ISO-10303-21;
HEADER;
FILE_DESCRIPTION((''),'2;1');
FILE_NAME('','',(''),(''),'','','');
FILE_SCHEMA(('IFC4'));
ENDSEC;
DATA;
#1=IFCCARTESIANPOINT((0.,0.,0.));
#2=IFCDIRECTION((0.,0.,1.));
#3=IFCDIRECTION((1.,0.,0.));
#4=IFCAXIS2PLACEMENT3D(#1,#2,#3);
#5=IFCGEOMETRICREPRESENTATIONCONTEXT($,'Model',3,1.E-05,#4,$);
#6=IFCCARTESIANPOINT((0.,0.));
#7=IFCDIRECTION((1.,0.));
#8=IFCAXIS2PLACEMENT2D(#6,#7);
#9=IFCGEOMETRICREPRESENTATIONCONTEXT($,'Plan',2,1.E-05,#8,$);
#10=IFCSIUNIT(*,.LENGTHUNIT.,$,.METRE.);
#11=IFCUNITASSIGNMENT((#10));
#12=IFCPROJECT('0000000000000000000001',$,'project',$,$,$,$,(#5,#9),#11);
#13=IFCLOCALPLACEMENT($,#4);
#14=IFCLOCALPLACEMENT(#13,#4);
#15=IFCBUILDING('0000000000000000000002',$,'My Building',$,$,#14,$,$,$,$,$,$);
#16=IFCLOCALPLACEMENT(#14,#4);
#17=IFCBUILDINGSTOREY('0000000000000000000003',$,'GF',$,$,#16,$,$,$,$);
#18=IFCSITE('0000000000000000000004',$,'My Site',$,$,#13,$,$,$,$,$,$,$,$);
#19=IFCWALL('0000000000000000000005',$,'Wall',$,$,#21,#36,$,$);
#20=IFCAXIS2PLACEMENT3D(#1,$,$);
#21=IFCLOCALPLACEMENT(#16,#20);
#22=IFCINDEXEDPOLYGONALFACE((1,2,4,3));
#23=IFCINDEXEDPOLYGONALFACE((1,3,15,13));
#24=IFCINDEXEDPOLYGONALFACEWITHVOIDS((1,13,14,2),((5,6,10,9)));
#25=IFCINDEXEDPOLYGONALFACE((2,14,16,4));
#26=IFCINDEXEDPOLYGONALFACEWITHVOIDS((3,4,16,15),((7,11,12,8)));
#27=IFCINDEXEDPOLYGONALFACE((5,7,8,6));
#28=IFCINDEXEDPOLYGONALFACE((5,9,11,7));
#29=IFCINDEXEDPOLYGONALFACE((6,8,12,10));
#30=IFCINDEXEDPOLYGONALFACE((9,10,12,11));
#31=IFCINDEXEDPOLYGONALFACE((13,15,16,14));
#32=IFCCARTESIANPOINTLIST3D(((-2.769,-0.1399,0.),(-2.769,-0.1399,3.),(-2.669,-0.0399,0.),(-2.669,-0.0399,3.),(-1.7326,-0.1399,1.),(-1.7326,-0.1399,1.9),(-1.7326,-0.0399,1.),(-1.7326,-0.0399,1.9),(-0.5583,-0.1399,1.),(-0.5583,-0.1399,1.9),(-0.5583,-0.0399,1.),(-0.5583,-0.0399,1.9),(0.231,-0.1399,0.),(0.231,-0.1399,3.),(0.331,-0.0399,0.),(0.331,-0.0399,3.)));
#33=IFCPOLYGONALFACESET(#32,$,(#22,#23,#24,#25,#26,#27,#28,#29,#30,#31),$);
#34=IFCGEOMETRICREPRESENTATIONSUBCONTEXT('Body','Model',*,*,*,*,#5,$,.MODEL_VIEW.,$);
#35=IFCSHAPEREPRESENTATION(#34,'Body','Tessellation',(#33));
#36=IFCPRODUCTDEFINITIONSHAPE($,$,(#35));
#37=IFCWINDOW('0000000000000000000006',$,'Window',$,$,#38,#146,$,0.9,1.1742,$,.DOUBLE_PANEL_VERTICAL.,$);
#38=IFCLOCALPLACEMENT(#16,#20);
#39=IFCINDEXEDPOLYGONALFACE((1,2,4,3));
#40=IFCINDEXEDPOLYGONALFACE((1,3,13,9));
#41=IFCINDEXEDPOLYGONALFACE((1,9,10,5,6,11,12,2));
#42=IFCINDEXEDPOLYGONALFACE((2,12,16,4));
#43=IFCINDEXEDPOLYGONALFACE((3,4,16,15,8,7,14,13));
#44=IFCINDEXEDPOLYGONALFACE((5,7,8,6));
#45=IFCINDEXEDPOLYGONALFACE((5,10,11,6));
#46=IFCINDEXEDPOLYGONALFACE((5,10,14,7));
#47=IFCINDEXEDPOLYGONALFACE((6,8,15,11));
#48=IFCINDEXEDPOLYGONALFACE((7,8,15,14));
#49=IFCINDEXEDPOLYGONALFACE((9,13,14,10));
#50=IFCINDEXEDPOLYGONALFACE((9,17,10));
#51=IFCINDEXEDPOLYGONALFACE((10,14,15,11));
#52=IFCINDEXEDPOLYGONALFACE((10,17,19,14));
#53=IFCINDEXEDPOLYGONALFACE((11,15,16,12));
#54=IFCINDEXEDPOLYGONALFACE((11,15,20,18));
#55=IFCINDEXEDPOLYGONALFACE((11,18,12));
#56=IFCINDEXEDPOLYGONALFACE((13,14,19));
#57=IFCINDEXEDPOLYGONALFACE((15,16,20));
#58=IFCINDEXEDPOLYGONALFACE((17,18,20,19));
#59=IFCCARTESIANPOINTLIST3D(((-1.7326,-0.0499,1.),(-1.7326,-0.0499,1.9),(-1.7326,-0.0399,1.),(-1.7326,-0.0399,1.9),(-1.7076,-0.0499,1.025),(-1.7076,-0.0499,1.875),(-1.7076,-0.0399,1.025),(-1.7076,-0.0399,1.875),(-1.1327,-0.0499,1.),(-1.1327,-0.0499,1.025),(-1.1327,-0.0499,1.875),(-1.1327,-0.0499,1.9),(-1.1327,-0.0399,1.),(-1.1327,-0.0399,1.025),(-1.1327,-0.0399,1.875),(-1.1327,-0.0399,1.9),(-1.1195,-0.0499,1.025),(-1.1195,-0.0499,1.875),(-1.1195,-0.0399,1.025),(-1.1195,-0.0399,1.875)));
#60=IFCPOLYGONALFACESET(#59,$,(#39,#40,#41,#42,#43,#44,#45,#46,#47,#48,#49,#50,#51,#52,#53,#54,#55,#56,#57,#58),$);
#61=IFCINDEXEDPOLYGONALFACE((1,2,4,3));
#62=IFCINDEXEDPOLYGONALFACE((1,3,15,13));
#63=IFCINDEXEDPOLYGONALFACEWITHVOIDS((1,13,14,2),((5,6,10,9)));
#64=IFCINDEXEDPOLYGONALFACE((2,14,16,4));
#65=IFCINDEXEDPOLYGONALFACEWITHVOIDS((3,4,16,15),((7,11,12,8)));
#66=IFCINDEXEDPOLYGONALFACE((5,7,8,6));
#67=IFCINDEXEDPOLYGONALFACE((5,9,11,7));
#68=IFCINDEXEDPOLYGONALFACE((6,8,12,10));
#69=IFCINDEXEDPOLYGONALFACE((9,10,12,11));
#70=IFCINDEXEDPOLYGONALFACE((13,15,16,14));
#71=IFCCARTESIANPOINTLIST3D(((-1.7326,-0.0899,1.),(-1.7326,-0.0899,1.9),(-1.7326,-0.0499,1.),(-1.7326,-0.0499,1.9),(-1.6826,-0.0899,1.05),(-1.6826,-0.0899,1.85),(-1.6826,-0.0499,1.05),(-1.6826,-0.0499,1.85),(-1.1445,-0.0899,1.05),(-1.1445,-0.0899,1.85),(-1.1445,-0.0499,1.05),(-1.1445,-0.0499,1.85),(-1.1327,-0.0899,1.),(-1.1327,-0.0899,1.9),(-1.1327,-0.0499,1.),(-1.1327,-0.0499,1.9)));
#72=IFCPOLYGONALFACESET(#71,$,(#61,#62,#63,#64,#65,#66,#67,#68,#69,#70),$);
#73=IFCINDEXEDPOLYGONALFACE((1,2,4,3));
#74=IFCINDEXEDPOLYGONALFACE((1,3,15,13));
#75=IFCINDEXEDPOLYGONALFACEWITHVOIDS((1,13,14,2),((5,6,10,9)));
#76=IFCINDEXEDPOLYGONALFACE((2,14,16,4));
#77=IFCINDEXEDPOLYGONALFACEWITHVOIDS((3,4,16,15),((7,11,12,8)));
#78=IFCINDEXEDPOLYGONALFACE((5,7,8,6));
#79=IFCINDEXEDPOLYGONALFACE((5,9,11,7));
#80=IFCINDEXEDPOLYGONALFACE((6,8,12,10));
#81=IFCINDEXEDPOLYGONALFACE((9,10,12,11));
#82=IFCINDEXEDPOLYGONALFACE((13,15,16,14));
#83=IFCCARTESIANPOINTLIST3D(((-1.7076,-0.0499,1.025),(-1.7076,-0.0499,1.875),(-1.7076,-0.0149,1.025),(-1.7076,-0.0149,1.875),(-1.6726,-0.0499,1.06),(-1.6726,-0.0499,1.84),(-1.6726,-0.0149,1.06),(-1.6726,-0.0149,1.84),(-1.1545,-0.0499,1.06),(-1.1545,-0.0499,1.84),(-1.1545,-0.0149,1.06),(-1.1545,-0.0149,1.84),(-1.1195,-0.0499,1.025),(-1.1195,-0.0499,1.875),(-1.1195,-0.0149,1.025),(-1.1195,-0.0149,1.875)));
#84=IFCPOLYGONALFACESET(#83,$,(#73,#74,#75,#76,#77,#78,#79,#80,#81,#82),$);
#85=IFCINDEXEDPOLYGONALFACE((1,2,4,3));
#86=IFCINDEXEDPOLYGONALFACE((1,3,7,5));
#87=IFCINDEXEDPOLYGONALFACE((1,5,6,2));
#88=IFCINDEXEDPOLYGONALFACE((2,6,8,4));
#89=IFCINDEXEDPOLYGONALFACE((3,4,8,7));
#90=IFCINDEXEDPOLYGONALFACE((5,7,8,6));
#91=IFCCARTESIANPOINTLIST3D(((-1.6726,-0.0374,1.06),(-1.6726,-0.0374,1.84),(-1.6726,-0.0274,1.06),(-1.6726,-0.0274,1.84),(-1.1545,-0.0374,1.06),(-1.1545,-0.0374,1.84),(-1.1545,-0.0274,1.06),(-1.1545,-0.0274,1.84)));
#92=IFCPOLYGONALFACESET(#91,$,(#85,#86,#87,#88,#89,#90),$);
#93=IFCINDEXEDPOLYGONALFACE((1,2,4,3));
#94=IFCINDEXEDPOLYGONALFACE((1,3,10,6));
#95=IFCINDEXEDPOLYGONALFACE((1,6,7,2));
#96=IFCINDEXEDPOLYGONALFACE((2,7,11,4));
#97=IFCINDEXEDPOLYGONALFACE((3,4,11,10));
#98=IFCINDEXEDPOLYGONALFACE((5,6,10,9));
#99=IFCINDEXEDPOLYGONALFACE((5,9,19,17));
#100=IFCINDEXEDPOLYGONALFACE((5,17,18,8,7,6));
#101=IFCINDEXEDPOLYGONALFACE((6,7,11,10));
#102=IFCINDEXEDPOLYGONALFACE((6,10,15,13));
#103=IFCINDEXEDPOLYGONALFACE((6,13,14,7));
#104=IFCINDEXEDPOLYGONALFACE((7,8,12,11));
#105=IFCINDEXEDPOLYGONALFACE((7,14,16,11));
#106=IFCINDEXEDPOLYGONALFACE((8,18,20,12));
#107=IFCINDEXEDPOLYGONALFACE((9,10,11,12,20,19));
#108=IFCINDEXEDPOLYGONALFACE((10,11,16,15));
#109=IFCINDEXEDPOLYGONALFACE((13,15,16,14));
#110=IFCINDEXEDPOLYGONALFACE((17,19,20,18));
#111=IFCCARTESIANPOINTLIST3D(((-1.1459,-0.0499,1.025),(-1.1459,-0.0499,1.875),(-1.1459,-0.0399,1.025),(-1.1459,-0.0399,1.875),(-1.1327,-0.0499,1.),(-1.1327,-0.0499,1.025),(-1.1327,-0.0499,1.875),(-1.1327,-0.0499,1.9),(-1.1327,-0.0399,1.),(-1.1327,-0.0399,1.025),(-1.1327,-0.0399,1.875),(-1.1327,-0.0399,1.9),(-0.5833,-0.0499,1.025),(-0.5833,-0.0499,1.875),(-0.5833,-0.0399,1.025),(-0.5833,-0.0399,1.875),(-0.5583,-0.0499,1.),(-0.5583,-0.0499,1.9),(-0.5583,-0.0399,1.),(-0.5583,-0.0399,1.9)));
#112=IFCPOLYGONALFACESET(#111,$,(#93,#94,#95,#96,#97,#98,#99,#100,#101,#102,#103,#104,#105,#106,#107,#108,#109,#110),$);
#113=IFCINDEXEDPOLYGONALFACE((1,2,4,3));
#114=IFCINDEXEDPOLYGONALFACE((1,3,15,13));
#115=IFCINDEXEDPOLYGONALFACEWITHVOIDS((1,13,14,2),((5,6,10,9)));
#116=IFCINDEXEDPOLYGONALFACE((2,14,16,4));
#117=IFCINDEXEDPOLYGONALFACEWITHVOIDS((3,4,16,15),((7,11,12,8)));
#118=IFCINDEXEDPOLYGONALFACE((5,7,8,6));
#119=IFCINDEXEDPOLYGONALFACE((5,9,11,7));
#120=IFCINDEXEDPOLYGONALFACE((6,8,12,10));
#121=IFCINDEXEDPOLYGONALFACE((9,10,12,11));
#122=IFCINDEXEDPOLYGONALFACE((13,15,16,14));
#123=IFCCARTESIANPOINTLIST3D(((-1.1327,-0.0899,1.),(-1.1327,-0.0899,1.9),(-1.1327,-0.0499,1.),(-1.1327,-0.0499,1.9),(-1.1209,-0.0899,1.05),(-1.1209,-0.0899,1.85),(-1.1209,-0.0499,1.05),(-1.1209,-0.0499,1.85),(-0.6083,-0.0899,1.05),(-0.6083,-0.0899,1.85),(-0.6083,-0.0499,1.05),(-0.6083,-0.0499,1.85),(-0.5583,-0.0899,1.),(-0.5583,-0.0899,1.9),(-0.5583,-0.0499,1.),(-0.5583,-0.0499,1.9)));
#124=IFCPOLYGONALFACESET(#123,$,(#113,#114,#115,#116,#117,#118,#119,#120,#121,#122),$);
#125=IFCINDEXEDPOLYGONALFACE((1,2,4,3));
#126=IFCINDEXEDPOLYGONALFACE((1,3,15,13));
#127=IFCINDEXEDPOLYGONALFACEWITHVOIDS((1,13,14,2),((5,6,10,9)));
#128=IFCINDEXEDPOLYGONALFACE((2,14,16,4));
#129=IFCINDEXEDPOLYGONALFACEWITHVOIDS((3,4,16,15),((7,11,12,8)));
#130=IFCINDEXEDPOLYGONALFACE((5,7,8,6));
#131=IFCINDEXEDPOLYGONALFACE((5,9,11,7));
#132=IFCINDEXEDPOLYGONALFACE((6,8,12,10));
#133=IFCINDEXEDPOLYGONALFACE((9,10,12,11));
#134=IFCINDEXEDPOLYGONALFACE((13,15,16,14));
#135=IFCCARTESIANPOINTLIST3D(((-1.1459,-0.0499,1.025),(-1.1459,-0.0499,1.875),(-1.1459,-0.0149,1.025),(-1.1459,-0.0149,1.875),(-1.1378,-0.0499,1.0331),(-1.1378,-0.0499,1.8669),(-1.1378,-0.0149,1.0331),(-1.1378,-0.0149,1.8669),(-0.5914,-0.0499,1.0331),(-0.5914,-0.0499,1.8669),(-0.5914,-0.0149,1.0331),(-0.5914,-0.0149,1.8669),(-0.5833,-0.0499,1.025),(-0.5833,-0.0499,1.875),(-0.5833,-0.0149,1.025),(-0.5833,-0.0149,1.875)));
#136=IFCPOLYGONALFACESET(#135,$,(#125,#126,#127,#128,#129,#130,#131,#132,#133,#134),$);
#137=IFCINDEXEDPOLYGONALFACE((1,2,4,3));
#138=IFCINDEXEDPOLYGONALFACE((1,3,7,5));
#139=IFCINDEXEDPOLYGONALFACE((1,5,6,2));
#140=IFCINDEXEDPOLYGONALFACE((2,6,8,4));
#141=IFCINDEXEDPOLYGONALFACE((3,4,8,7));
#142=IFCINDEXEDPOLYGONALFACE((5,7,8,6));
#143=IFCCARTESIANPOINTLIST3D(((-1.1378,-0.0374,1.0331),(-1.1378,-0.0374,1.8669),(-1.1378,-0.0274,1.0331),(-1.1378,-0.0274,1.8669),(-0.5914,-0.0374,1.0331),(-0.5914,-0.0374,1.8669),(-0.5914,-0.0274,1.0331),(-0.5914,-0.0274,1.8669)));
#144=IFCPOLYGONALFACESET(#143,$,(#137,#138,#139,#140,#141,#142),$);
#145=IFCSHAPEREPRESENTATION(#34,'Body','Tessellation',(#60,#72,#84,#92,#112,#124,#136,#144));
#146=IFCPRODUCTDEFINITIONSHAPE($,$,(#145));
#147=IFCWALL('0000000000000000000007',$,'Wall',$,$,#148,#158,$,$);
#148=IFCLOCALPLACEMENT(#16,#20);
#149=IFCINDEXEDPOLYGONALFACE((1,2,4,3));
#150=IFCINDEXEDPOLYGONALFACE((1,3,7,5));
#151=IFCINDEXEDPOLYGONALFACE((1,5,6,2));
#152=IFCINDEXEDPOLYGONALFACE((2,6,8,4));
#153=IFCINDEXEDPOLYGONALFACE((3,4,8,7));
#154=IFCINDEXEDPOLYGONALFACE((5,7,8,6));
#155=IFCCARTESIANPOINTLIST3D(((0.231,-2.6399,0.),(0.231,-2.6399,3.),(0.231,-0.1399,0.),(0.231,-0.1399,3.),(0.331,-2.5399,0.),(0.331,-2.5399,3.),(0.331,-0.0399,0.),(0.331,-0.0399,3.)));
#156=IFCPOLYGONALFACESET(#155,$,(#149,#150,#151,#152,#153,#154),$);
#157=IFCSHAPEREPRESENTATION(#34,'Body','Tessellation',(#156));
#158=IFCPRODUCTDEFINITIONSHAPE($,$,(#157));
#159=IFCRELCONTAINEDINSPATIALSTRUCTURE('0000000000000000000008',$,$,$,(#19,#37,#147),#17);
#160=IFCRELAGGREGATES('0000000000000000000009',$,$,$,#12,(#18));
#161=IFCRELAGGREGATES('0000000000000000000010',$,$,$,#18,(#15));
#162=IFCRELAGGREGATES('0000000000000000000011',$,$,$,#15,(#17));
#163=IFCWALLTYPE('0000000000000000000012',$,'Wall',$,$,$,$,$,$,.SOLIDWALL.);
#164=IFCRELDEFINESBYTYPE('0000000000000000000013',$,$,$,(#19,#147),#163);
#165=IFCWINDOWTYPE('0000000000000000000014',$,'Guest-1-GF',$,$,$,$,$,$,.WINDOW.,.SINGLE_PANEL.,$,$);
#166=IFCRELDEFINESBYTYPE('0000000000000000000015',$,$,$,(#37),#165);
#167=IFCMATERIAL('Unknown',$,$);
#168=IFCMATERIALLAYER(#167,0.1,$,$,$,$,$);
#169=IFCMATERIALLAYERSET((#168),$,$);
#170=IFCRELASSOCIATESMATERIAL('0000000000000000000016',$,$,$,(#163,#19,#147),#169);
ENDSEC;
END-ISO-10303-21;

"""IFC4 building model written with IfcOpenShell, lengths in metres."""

from ifc_helpers import new_model, entity, si_unit, frame, origin_with_axes, origin_2d_with_axis, place, context, subcontext, project, spatial, line, indexed_curve, outline, extrude, shape, source, transform, mapped, material, layer, layer_set, layer_usage, type_object, type_shapes, element, fill, save


model = new_model("IFC4")

# Units and contexts
model_context = context("Model", 3, precision=1e-05, world=origin_with_axes())
plan_context = context("Plan", 2, precision=1e-05, world=origin_2d_with_axis())
body_context_1 = subcontext(model_context, "Body", "Model", "MODEL_VIEW")
body_context_2 = subcontext(plan_context, "Body", "Plan", "PLAN_VIEW")
ifc_project = project(units=[si_unit("LENGTHUNIT", "METRE")], contexts=[model_context, plan_context])

# Site, building, storey
site_placement = place(None, origin_with_axes())
site = spatial("IfcSite", under=ifc_project, at=site_placement, Name="My Site")
building_placement = place(site_placement, origin_with_axes())
building = spatial("IfcBuilding", under=site, at=building_placement, Name="My Building")
storey_placement = place(building_placement, origin_with_axes())
storey = spatial("IfcBuildingStorey", under=building, at=storey_placement, Name="GF")

# Shared definitions
ifc_material = material(Name="Unknown")

# Shared definitions
ifc_layer_1 = layer(ifc_material, 0.1)
ifc_layer_set_1 = layer_set([ifc_layer_1])
wall_type = type_object("IfcWallType", Name="Wall", PredefinedType="SOLIDWALL", material=ifc_layer_set_1)

# Wall, opening, window
ifc_layer_usage_1 = layer_usage(ifc_layer_set_1, "AXIS2", "POSITIVE", 0.0)
wall_1_placement = place(storey_placement, frame((-2.769, -0.1399, 0.0), z_axis=(0.0, 0.0, 1.0), x_axis=(1.0, 0.0, 0.0)))
wall_1 = element("IfcWall", 1, at=wall_1_placement, inside=storey, type_object=wall_type, material=ifc_layer_usage_1, Name="Wall", context=body_context_1, shape_type="SweptSolid", body=[
    extrude(outline(indexed_curve([(0.0, 0.0), (0.1, 0.1), (3.1, 0.1), (3.0, 0.0)], segments=[line(1, 2, 3, 4, 1)])), origin_with_axes(), (0.0, 0.0, 1.0), 3.0),
])
shared_shape_1 = source(origin_with_axes(), body_context_1, "Body", "SweptSolid", [
    extrude(outline(indexed_curve([(0.0, 0.0), (1.1742, 0.0), (1.1742, 0.9), (0.0, 0.9)], segments=[line(1, 2, 3, 4, 1)])), frame((0.0, -0.6, 0.0), z_axis=(0.0, -1.0, 0.0), x_axis=(1.0, 0.0, 0.0)), (0.0, 0.0, -1.0), 1.2),
])
opening_1_placement = place(wall_1_placement, frame((1.0365, 0.0, 1.0), z_axis=(0.0, 0.0, 1.0), x_axis=(1.0, 0.0, 0.0)))
opening_1 = element("IfcOpeningElement", 2, at=opening_1_placement, cuts=wall_1, PredefinedType="OPENING", context=body_context_1, shape_type="MappedRepresentation", body=[
    mapped(shared_shape_1, transform((0.0, 0.0, 0.0), x_axis=(1.0, 0.0, 0.0), y_axis=(0.0, 1.0, 0.0), z_axis=(0.0, 0.0, 1.0), scale=1.0)),
])
window_type_1 = type_object("IfcWindowType", Name="Guest-1-GF", PartitioningType="SINGLE_PANEL", PredefinedType="WINDOW")
shared_shape_2 = source(origin_with_axes(), body_context_1, "Body", "SweptSolid", [
    extrude(outline(indexed_curve([(0.0, 0.0), (0.5999, 0.0), (0.5999, 0.9), (0.0, 0.9)], segments=[line(1, 2, 3, 4, 1)]), holes=[indexed_curve([(0.025, 0.025), (0.6131, 0.025), (0.6131, 0.875), (0.025, 0.875)], segments=[line(1, 2, 3, 4, 1)])]), frame((0.0, 0.09, 0.0), z_axis=(0.0, -1.0, 0.0), x_axis=(1.0, 0.0, 0.0)), (0.0, 0.0, -1.0), 0.01),
    extrude(outline(indexed_curve([(0.0, 0.0), (0.5999, 0.0), (0.5999, 0.9), (0.0, 0.9)], segments=[line(1, 2, 3, 4, 1)]), holes=[indexed_curve([(0.05, 0.05), (0.5881, 0.05), (0.5881, 0.85), (0.05, 0.85)], segments=[line(1, 2, 3, 4, 1)])]), frame((0.0, 0.05, 0.0), z_axis=(0.0, -1.0, 0.0), x_axis=(1.0, 0.0, 0.0)), (0.0, 0.0, -1.0), 0.04),
    extrude(outline(indexed_curve([(0.0, 0.0), (0.5881, 0.0), (0.5881, 0.85), (0.0, 0.85)], segments=[line(1, 2, 3, 4, 1)]), holes=[indexed_curve([(0.035, 0.035), (0.5531, 0.035), (0.5531, 0.815), (0.035, 0.815)], segments=[line(1, 2, 3, 4, 1)])]), frame((0.025, 0.09, 0.025), z_axis=(0.0, -1.0, 0.0), x_axis=(1.0, 0.0, 0.0)), (0.0, 0.0, -1.0), 0.035),
    extrude(outline(indexed_curve([(0.035, 0.035), (0.5531, 0.035), (0.5531, 0.815), (0.035, 0.815)], segments=[line(1, 2, 3, 4, 1)])), frame((0.025, 0.1025, 0.025), z_axis=(0.0, -1.0, 0.0), x_axis=(1.0, 0.0, 0.0)), (0.0, 0.0, -1.0), 0.01),
    extrude(outline(indexed_curve([(0.0, 0.0), (0.5744, 0.0), (0.5744, 0.9), (0.0, 0.9)], segments=[line(1, 2, 3, 4, 1)]), holes=[indexed_curve([(-0.0132, 0.025), (0.5494, 0.025), (0.5494, 0.875), (-0.0132, 0.875)], segments=[line(1, 2, 3, 4, 1)])]), frame((0.5999, 0.09, 0.0), z_axis=(0.0, -1.0, 0.0), x_axis=(1.0, 0.0, 0.0)), (0.0, 0.0, -1.0), 0.01),
    extrude(outline(indexed_curve([(0.0, 0.0), (0.5744, 0.0), (0.5744, 0.9), (0.0, 0.9)], segments=[line(1, 2, 3, 4, 1)]), holes=[indexed_curve([(0.0118, 0.05), (0.5244, 0.05), (0.5244, 0.85), (0.0118, 0.85)], segments=[line(1, 2, 3, 4, 1)])]), frame((0.5999, 0.05, 0.0), z_axis=(0.0, -1.0, 0.0), x_axis=(1.0, 0.0, 0.0)), (0.0, 0.0, -1.0), 0.04),
    extrude(outline(indexed_curve([(0.0, 0.0), (0.5626, 0.0), (0.5626, 0.85), (0.0, 0.85)], segments=[line(1, 2, 3, 4, 1)]), holes=[indexed_curve([(0.0081, 0.0081), (0.5545, 0.0081), (0.5545, 0.8419), (0.0081, 0.8419)], segments=[line(1, 2, 3, 4, 1)])]), frame((0.5866, 0.09, 0.025), z_axis=(0.0, -1.0, 0.0), x_axis=(1.0, 0.0, 0.0)), (0.0, 0.0, -1.0), 0.035),
    extrude(outline(indexed_curve([(0.0081, 0.0081), (0.5545, 0.0081), (0.5545, 0.8419), (0.0081, 0.8419)], segments=[line(1, 2, 3, 4, 1)])), frame((0.5866, 0.1025, 0.025), z_axis=(0.0, -1.0, 0.0), x_axis=(1.0, 0.0, 0.0)), (0.0, 0.0, -1.0), 0.01),
])
shared_shape_3 = source(origin_with_axes(), body_context_2, "Body", "Curve2D", [
    entity("IfcIndexedPolyCurve", entity("IfcCartesianPointList2D", [[0.05, 0.05], [0.5881, 0.05]])),
    entity("IfcIndexedPolyCurve", entity("IfcCartesianPointList2D", [[0.0, 0.1], [0.025, 0.1], [0.025, 0.09], [0.05, 0.09], [0.05, 0.05], [0.0, 0.05]]), [entity("IfcLineIndex", [1, 2, 3, 4, 5, 6, 1])]),
    entity("IfcIndexedPolyCurve", entity("IfcCartesianPointList2D", [[0.5999, 0.1], [0.6131, 0.1], [0.6131, 0.09], [0.5881, 0.09], [0.5881, 0.05], [0.5999, 0.05]])),
    entity("IfcIndexedPolyCurve", entity("IfcCartesianPointList2D", [[0.025, 0.09], [0.06, 0.09], [0.06, 0.125], [0.025, 0.125]]), [entity("IfcLineIndex", [1, 2, 3, 4, 1])]),
    entity("IfcIndexedPolyCurve", entity("IfcCartesianPointList2D", [[0.6131, 0.09], [0.5781, 0.09], [0.5781, 0.125], [0.6131, 0.125]]), [entity("IfcLineIndex", [1, 2, 3, 4, 1])]),
    entity("IfcIndexedPolyCurve", entity("IfcCartesianPointList2D", [[0.06, 0.09], [0.5781, 0.09]])),
    entity("IfcIndexedPolyCurve", entity("IfcCartesianPointList2D", [[0.06, 0.125], [0.5781, 0.125]])),
    entity("IfcIndexedPolyCurve", entity("IfcCartesianPointList2D", [[0.06, 0.1075], [0.5781, 0.1075]])),
    entity("IfcIndexedPolyCurve", entity("IfcCartesianPointList2D", [[0.6116, 0.05], [1.1242, 0.05]])),
    entity("IfcIndexedPolyCurve", entity("IfcCartesianPointList2D", [[0.5999, 0.1], [0.5866, 0.1], [0.5866, 0.09], [0.6116, 0.09], [0.6116, 0.05], [0.5999, 0.05]])),
    entity("IfcIndexedPolyCurve", entity("IfcCartesianPointList2D", [[1.1742, 0.1], [1.1492, 0.1], [1.1492, 0.09], [1.1242, 0.09], [1.1242, 0.05], [1.1742, 0.05]]), [entity("IfcLineIndex", [1, 2, 3, 4, 5, 6, 1])]),
    entity("IfcIndexedPolyCurve", entity("IfcCartesianPointList2D", [[0.5866, 0.09], [0.5947, 0.09], [0.5947, 0.125], [0.5866, 0.125]]), [entity("IfcLineIndex", [1, 2, 3, 4, 1])]),
    entity("IfcIndexedPolyCurve", entity("IfcCartesianPointList2D", [[1.1492, 0.09], [1.1412, 0.09], [1.1412, 0.125], [1.1492, 0.125]]), [entity("IfcLineIndex", [1, 2, 3, 4, 1])]),
    entity("IfcIndexedPolyCurve", entity("IfcCartesianPointList2D", [[0.5947, 0.09], [1.1412, 0.09]])),
    entity("IfcIndexedPolyCurve", entity("IfcCartesianPointList2D", [[0.5947, 0.125], [1.1412, 0.125]])),
    entity("IfcIndexedPolyCurve", entity("IfcCartesianPointList2D", [[0.5947, 0.1075], [1.1412, 0.1075]])),
])
type_shapes(window_type_1, [shared_shape_2, shared_shape_3])
window_1_placement = place(opening_1_placement, origin_with_axes())
window_1 = element("IfcWindow", 3, at=window_1_placement, inside=storey, type_object=window_type_1, Name="Window", OverallHeight=0.9, OverallWidth=1.1742, PartitioningType="DOUBLE_PANEL_VERTICAL", shapes=[
    shape(body_context_1, "Body", "MappedRepresentation", [mapped(shared_shape_2, transform((0.0, 0.0, 0.0), x_axis=(1.0, 0.0, 0.0), y_axis=(0.0, 1.0, 0.0), z_axis=(0.0, 0.0, 1.0), scale=1.0))]),
    shape(body_context_2, "Body", "MappedRepresentation", [mapped(shared_shape_3, transform((0.0, 0.0, 0.0), x_axis=(1.0, 0.0, 0.0), y_axis=(0.0, 1.0, 0.0), z_axis=(0.0, 0.0, 1.0), scale=1.0))]),
])
fill(opening_1, window_1)

# Wall
ifc_layer_usage_2 = layer_usage(ifc_layer_set_1, "AXIS2", "POSITIVE", 0.0)
wall_2_placement = place(storey_placement, frame((0.231, -0.1399, 0.0), z_axis=(0.0, 0.0, 1.0), x_axis=(0.0, -1.0, 0.0)))
element("IfcWall", 4, at=wall_2_placement, inside=storey, type_object=wall_type, material=ifc_layer_usage_2, Name="Wall", context=body_context_1, shape_type="SweptSolid", body=[
    extrude(outline(indexed_curve([(0.0, 0.0), (-0.1, 0.1), (2.4, 0.1), (2.5, 0.0)], segments=[line(1, 2, 3, 4, 1)])), origin_with_axes(), (0.0, 0.0, 1.0), 3.0),
])

save(model, "model.ifc")
